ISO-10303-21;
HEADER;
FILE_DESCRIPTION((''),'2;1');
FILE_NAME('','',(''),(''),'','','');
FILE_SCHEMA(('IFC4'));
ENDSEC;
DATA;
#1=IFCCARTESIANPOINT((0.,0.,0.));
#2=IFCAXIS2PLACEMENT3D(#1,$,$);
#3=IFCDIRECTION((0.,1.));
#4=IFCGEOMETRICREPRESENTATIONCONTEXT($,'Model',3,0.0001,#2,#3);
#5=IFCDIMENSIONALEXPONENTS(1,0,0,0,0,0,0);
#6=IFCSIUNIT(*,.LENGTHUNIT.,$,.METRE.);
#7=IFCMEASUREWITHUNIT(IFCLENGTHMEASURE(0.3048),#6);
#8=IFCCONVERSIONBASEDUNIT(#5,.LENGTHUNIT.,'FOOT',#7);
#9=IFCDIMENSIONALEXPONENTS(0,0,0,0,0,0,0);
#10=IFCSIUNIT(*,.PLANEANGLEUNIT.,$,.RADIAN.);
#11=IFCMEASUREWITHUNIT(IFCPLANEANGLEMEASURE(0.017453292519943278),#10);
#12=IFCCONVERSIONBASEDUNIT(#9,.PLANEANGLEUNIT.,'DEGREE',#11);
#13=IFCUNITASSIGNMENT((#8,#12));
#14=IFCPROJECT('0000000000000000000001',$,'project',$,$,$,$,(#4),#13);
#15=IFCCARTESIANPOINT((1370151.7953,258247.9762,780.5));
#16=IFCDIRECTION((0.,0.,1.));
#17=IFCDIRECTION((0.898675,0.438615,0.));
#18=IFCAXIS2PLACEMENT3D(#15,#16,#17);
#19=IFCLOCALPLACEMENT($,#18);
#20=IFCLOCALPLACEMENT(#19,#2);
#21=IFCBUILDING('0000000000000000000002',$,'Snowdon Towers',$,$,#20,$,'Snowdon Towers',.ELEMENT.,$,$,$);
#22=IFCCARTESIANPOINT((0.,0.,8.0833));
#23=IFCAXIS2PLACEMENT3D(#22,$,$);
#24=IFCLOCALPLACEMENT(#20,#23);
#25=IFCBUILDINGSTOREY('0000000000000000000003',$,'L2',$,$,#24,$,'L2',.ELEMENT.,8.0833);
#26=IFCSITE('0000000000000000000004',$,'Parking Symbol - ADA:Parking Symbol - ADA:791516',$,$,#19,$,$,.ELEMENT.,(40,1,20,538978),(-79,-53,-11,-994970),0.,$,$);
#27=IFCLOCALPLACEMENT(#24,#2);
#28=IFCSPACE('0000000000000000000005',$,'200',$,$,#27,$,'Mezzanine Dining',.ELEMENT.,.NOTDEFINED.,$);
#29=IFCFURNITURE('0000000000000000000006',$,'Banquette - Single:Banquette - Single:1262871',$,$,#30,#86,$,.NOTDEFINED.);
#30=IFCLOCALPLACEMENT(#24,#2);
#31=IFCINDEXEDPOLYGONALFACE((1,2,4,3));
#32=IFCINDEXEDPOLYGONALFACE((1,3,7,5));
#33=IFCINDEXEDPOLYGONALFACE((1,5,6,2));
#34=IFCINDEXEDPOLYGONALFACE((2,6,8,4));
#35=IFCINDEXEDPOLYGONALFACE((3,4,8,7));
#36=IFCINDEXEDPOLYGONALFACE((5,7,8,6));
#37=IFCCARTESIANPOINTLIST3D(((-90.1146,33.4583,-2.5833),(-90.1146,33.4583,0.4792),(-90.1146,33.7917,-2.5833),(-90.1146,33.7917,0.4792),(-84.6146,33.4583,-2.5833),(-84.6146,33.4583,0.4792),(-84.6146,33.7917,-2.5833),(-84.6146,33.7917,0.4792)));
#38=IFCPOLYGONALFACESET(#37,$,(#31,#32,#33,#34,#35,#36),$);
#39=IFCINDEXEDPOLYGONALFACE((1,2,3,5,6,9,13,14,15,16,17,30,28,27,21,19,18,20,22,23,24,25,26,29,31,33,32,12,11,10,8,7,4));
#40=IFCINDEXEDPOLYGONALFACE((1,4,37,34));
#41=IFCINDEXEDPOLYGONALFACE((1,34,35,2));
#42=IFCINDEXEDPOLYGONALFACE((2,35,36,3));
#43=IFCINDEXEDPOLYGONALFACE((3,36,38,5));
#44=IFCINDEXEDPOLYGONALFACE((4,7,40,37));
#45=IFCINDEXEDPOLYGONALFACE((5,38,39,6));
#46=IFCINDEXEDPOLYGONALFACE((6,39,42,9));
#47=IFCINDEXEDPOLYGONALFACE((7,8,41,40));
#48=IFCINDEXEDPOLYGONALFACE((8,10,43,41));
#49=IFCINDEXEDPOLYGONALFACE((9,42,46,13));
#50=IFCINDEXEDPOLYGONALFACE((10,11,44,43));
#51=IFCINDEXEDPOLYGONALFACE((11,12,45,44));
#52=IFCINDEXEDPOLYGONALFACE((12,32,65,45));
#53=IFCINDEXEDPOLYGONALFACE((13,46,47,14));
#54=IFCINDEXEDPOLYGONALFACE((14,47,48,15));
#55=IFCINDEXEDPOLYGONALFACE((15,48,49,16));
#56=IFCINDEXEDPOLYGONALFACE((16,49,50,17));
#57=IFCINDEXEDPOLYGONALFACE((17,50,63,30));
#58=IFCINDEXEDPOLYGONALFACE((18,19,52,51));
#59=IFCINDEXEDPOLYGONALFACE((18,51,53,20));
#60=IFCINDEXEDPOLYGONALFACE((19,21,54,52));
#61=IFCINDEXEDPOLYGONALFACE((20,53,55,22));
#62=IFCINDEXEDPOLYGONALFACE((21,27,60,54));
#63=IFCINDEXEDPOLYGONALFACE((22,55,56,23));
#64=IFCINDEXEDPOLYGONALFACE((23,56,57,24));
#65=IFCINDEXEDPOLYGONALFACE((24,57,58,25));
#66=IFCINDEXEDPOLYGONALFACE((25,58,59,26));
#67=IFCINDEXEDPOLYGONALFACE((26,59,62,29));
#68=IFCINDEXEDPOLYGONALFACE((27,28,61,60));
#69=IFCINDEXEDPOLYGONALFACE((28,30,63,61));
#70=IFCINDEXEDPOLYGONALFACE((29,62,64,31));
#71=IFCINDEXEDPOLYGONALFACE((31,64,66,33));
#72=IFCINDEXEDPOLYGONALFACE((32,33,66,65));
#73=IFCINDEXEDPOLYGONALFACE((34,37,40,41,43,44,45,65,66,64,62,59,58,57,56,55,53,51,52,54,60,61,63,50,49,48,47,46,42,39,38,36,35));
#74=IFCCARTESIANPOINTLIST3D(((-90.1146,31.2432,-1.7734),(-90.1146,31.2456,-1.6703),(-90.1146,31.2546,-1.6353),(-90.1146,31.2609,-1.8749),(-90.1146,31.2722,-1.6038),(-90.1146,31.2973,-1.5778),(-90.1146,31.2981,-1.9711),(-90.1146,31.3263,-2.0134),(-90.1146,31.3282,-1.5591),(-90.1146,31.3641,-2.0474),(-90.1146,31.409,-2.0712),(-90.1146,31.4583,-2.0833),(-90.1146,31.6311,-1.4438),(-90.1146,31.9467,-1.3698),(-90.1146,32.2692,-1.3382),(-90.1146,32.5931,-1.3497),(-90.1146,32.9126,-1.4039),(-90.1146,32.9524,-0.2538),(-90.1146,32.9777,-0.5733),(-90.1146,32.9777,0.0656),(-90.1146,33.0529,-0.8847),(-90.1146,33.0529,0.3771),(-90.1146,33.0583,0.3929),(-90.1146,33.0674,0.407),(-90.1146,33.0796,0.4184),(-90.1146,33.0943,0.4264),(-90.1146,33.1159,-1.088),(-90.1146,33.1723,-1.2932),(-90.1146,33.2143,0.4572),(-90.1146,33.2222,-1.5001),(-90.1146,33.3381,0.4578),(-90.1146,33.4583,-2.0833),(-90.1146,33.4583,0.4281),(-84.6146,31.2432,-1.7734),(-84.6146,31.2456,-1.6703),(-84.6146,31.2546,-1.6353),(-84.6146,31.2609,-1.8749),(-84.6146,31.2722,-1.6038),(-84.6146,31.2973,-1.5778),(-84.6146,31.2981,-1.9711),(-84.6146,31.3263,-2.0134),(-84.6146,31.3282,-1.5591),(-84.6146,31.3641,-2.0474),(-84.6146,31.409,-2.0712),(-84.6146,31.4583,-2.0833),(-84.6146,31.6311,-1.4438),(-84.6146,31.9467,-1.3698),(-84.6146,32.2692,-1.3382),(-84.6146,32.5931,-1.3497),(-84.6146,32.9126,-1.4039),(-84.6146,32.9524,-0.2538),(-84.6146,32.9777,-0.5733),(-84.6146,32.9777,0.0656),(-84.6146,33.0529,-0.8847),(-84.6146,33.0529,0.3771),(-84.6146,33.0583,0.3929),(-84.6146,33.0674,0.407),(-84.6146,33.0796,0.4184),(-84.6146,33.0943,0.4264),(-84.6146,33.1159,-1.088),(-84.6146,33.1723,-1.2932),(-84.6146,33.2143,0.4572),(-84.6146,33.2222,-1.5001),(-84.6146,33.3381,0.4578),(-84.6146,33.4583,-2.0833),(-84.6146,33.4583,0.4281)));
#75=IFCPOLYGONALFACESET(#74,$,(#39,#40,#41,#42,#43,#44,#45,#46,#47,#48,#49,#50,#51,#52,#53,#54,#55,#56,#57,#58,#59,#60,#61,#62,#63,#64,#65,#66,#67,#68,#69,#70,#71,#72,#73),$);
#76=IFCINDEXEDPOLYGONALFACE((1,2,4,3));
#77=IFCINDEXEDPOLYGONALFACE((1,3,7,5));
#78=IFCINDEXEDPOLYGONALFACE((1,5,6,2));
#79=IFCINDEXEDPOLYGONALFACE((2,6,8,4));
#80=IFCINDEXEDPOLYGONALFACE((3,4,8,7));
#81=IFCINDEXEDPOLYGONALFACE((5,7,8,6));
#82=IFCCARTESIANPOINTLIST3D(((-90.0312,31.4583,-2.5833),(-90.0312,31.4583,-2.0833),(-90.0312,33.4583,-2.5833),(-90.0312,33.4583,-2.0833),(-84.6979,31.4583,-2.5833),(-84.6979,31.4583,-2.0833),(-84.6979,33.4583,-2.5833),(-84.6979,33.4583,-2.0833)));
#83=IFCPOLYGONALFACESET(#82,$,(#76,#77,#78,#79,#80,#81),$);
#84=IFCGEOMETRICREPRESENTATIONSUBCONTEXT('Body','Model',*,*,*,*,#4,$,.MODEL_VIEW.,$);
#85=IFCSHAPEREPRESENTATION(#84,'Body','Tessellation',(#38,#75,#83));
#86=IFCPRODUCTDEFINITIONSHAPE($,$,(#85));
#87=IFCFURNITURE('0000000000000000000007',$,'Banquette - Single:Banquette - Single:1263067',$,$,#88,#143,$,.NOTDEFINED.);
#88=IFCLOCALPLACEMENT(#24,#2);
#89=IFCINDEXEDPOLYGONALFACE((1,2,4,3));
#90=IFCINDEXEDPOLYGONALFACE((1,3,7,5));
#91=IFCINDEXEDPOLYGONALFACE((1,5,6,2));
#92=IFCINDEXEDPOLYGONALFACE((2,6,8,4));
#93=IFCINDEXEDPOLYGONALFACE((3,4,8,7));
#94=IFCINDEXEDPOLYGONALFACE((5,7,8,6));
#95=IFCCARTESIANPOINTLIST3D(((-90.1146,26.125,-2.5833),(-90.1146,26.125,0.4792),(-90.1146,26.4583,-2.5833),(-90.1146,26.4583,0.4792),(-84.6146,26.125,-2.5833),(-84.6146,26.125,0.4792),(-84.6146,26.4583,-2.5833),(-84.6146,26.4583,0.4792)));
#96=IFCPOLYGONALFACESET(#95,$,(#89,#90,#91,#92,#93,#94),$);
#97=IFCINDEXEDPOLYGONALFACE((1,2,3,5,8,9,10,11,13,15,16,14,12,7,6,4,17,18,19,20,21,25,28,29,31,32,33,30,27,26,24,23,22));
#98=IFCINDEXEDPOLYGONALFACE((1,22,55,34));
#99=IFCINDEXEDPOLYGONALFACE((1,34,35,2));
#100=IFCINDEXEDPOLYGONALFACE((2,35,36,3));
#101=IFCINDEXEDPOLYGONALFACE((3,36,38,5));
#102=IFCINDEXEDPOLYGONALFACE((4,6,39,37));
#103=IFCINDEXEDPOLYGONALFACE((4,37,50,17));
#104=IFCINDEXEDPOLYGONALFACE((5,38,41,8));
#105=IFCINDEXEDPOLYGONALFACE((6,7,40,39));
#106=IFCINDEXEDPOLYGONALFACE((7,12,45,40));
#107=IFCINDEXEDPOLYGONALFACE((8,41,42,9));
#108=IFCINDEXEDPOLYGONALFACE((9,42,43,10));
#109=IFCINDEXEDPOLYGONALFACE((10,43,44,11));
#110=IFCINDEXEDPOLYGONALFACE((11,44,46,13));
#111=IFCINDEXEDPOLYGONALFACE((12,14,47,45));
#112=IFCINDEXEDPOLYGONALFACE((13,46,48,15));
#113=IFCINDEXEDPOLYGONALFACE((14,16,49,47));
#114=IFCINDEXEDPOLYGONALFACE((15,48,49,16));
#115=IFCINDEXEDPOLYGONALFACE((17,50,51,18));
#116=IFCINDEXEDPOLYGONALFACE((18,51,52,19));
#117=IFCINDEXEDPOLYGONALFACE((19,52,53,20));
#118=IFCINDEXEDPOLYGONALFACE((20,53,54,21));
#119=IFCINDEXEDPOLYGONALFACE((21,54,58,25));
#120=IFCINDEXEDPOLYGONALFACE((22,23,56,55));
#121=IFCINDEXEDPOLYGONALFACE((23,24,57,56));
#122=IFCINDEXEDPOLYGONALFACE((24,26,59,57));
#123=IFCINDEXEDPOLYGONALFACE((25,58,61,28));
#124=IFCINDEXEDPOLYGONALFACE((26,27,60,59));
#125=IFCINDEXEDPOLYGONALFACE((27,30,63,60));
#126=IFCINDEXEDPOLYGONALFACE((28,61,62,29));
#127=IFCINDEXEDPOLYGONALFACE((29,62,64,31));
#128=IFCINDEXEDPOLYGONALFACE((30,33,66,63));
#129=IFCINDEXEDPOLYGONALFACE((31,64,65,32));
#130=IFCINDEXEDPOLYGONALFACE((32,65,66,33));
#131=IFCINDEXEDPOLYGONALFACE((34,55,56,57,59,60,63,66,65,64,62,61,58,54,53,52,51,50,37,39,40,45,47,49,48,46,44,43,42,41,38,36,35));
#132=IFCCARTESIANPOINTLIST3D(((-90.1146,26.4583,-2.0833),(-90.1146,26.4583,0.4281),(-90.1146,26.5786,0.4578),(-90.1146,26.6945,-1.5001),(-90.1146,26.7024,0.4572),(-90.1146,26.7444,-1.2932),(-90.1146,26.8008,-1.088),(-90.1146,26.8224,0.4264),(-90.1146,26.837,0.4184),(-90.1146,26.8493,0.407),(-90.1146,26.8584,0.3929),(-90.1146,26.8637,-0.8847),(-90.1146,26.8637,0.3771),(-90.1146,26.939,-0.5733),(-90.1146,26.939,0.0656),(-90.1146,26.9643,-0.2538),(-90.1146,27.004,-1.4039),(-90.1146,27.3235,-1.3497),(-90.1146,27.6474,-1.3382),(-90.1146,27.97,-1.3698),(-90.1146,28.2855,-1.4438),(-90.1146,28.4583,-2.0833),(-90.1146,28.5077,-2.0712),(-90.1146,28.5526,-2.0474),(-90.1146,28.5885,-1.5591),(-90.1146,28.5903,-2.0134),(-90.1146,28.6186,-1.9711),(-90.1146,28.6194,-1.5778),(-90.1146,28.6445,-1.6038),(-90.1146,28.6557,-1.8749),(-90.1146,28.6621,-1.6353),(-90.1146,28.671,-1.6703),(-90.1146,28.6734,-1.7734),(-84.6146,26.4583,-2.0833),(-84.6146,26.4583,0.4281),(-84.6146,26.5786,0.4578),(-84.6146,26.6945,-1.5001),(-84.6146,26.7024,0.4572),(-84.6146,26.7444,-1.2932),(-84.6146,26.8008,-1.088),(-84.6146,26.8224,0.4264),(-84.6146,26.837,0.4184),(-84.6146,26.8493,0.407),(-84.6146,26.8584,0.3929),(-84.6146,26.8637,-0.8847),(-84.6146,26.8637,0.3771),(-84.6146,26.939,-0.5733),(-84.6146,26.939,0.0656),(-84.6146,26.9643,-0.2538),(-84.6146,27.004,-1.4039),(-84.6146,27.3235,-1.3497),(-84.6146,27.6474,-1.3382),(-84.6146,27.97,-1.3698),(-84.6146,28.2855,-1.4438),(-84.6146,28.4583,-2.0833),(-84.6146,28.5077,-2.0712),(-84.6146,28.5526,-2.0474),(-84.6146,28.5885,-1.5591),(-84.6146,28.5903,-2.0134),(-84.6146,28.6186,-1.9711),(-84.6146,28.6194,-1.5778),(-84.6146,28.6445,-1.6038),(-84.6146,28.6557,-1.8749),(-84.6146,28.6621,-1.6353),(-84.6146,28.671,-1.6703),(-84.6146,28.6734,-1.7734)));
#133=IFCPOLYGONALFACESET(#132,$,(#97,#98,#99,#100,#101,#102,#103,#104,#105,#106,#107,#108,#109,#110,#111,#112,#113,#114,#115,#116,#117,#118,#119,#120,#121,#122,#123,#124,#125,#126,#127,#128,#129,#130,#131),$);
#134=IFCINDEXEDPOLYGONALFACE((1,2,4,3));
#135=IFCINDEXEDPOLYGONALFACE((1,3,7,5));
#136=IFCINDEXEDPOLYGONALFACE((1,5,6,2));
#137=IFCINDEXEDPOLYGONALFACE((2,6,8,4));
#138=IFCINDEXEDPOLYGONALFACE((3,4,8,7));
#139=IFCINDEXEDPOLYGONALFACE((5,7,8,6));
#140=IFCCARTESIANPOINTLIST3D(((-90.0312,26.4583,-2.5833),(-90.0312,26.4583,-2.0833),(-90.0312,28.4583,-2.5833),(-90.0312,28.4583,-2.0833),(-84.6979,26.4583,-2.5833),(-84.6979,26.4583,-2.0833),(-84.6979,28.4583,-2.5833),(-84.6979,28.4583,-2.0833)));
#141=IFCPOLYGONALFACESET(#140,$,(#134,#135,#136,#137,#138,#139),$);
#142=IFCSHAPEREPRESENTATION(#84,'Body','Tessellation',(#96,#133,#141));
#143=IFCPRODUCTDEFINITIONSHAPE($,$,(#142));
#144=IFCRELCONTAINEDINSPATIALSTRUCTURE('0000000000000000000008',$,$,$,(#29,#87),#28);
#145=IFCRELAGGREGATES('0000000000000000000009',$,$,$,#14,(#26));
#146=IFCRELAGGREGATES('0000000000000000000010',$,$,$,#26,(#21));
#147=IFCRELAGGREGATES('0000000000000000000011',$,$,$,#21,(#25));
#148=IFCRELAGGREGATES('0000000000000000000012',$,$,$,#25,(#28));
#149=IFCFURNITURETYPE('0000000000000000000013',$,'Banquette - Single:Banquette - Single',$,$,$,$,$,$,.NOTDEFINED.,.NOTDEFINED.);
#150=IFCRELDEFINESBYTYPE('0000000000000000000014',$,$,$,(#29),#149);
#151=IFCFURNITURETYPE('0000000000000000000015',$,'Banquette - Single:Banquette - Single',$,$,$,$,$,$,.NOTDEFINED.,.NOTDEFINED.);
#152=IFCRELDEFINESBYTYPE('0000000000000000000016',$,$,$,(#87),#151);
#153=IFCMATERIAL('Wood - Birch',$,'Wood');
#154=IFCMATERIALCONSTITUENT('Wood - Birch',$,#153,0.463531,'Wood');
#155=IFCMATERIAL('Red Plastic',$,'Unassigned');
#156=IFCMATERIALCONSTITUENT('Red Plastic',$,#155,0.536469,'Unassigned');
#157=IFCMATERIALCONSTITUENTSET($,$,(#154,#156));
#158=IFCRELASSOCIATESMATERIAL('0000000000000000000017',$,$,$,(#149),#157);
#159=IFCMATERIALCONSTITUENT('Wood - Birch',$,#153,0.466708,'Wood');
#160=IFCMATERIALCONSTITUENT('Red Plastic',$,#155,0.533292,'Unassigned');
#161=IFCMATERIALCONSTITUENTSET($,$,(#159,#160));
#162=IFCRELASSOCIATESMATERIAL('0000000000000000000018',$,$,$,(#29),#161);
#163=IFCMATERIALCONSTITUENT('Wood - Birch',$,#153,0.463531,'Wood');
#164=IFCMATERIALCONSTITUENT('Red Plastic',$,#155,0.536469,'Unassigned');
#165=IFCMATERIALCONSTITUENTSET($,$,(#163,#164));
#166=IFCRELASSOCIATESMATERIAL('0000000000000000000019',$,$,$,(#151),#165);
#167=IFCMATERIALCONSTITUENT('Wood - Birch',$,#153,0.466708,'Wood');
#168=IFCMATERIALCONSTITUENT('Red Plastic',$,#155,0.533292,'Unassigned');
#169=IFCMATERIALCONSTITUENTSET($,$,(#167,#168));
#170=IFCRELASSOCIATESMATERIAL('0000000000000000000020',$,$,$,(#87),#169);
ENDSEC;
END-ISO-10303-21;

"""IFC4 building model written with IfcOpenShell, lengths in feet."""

from ifc_helpers import new_model, entity, si_unit, converted_unit, direction, frame, origin, place, context, subcontext, project, spatial, line, arc, indexed_curve, outline, extrude, source, transform, mapped, material, constituent, constituent_set, type_object, type_shapes, element, save


model = new_model("IFC4")

# Units and contexts
model_context = context("Model", 3, precision=0.0001, world=origin(), true_north=direction((0.0, 1.0)))
body_context = subcontext(model_context, "Body", "Model", "MODEL_VIEW")
ifc_project = project(units=[converted_unit("LENGTHUNIT", "FOOT", entity("IfcLengthMeasure", 0.3048), si_unit("LENGTHUNIT", "METRE"), dimensions=[1, 0, 0, 0, 0, 0, 0]), converted_unit("PLANEANGLEUNIT", "DEGREE", entity("IfcPlaneAngleMeasure", 0.017453292519943278), si_unit("PLANEANGLEUNIT", "RADIAN"), dimensions=[0, 0, 0, 0, 0, 0, 0])], contexts=[model_context])

# Site, building, storey
site_placement = place(None, frame((1370151.7953, 258247.9762, 780.5), z_axis=(0.0, 0.0, 1.0), x_axis=(0.898675, 0.438615, 0.0)))
site = spatial("IfcSite", under=ifc_project, at=site_placement, Name="Parking Symbol - ADA:Parking Symbol - ADA:791516", CompositionType="ELEMENT", RefLatitude=(40, 1, 20, 538978), RefLongitude=(-79, -53, -11, -994970), RefElevation=0.0)
building_placement = place(site_placement, origin())
building = spatial("IfcBuilding", under=site, at=building_placement, Name="Snowdon Towers", LongName="Snowdon Towers", CompositionType="ELEMENT")
storey_placement = place(building_placement, frame((0.0, 0.0, 8.0833)))
storey = spatial("IfcBuildingStorey", under=building, at=storey_placement, Name="L2", LongName="L2", CompositionType="ELEMENT", Elevation=8.0833)

# Shared definitions
space_1_placement = place(storey_placement, origin())
space_1 = spatial("IfcSpace", under=storey, at=space_1_placement, Name="200", LongName="Mezzanine Dining", CompositionType="ELEMENT", PredefinedType="NOTDEFINED")

# Furniture
ifc_material_1 = material(Name="Wood - Birch", Category="Wood")
ifc_constituent_1 = constituent(ifc_material_1, Name="Wood - Birch", Category="Wood", fraction=0.466708)
ifc_material_2 = material(Name="Red Plastic", Category="Unassigned")
ifc_constituent_2 = constituent(ifc_material_2, Name="Red Plastic", Category="Unassigned", fraction=0.533292)
ifc_constituent_set_1 = constituent_set(constituents=[ifc_constituent_1, ifc_constituent_2])
ifc_constituent_3 = constituent(ifc_material_1, Name="Wood - Birch", Category="Wood", fraction=0.463531)
ifc_constituent_4 = constituent(ifc_material_2, Name="Red Plastic", Category="Unassigned", fraction=0.536469)
ifc_constituent_set_2 = constituent_set(constituents=[ifc_constituent_3, ifc_constituent_4])
furniture_type_1 = type_object("IfcFurnitureType", Name="Banquette - Single:Banquette - Single", AssemblyPlace="NOTDEFINED", PredefinedType="NOTDEFINED", material=ifc_constituent_set_2)
shared_shape_1 = source(origin(), body_context, "Body", "SweptSolid", [
    extrude(outline(indexed_curve([(-2.75, -0.1667), (2.75, -0.1667), (2.75, 0.1667), (-2.75, 0.1667), (-2.75, -0.1667)], self_intersect=False)), frame((-0.1667, -2.75, 0.0), z_axis=(0.0, 0.0, 1.0), x_axis=(0.0, -1.0, 0.0)), (0.0, 0.0, 1.0), 3.0625),
    extrude(outline(indexed_curve([(1.1689, 0.9191), (1.1029, 0.9954), (1.0086, 1.0313), (-0.9914, 1.0313), (-0.9914, -1.4801), (-0.8092, -1.5134), (-0.6274, -1.4784), (-0.6004, -1.459), (-0.586, -1.4291), (-0.4855, -0.7982), (-0.586, -0.1673), (-0.678, 0.1384), (-0.7552, 0.4481), (0.1977, 0.2862), (1.1387, 0.507), (1.1947, 0.5517), (1.2213, 0.6183), (1.2173, 0.7725)], segments=[arc(1, 2, 3), line(3, 4, 5), arc(5, 6, 7), arc(7, 8, 9), arc(9, 10, 11), arc(11, 12, 13), arc(13, 14, 15), arc(15, 16, 17), arc(17, 18, 1)], self_intersect=False)), frame((0.9914, -5.5, 1.5313), z_axis=(0.0, 1.0, 0.0), x_axis=(1.0, 0.0, 0.0)), (0.0, 0.0, 1.0), 5.5),
    extrude(outline(indexed_curve([(-1.0, -2.6667), (1.0, -2.6667), (1.0, 2.6667), (-1.0, 2.6667), (-1.0, -2.6667)], self_intersect=False)), frame((1.0, -2.75, 0.0), z_axis=(0.0, 0.0, 1.0), x_axis=(-1.0, 0.0, 0.0)), (0.0, 0.0, 1.0), 0.5),
])
type_shapes(furniture_type_1, [shared_shape_1])
furniture_1_placement = place(space_1_placement, frame((-84.6146, 33.4583, -2.5833), z_axis=(0.0, 0.0, 1.0), x_axis=(0.0, -1.0, 0.0)))
element("IfcFurniture", 1, at=furniture_1_placement, inside=space_1, type_object=furniture_type_1, material=ifc_constituent_set_1, Name="Banquette - Single:Banquette - Single:1262871", PredefinedType="NOTDEFINED", context=body_context, shape_type="MappedRepresentation", body=[
    mapped(shared_shape_1, transform((0.0, 0.0, 0.0), scale=1.0)),
])
ifc_constituent_5 = constituent(ifc_material_1, Name="Wood - Birch", Category="Wood", fraction=0.466708)
ifc_constituent_6 = constituent(ifc_material_2, Name="Red Plastic", Category="Unassigned", fraction=0.533292)
ifc_constituent_set_3 = constituent_set(constituents=[ifc_constituent_5, ifc_constituent_6])
ifc_constituent_7 = constituent(ifc_material_1, Name="Wood - Birch", Category="Wood", fraction=0.463531)
ifc_constituent_8 = constituent(ifc_material_2, Name="Red Plastic", Category="Unassigned", fraction=0.536469)
ifc_constituent_set_4 = constituent_set(constituents=[ifc_constituent_7, ifc_constituent_8])
furniture_type_2 = type_object("IfcFurnitureType", Name="Banquette - Single:Banquette - Single", AssemblyPlace="NOTDEFINED", PredefinedType="NOTDEFINED", material=ifc_constituent_set_4)
shared_shape_2 = source(origin(), body_context, "Body", "SweptSolid", [
    extrude(outline(indexed_curve([(-0.1667, -2.75), (0.1667, -2.75), (0.1667, 2.75), (-0.1667, 2.75), (-0.1667, -2.75)], self_intersect=False)), frame((-0.1667, 2.75, 0.0)), (0.0, 0.0, 1.0), 3.0625),
    extrude(outline(indexed_curve([(1.1689, 0.9191), (1.1029, 0.9954), (1.0086, 1.0313), (-0.9914, 1.0313), (-0.9914, -1.4801), (-0.8092, -1.5134), (-0.6274, -1.4784), (-0.6004, -1.459), (-0.586, -1.4291), (-0.4855, -0.7982), (-0.586, -0.1673), (-0.678, 0.1384), (-0.7552, 0.4481), (0.1977, 0.2862), (1.1387, 0.507), (1.1947, 0.5517), (1.2213, 0.6183), (1.2173, 0.7725)], segments=[arc(1, 2, 3), line(3, 4, 5), arc(5, 6, 7), arc(7, 8, 9), arc(9, 10, 11), arc(11, 12, 13), arc(13, 14, 15), arc(15, 16, 17), arc(17, 18, 1)], self_intersect=False)), frame((0.9914, 0.0, 1.5313), z_axis=(0.0, 1.0, 0.0), x_axis=(1.0, 0.0, 0.0)), (0.0, 0.0, 1.0), 5.5),
    extrude(outline(indexed_curve([(-2.6667, -1.0), (2.6667, -1.0), (2.6667, 1.0), (-2.6667, 1.0), (-2.6667, -1.0)], self_intersect=False)), frame((1.0, 2.75, 0.0), z_axis=(0.0, 0.0, 1.0), x_axis=(0.0, 1.0, 0.0)), (0.0, 0.0, 1.0), 0.5),
])
type_shapes(furniture_type_2, [shared_shape_2])
furniture_2_placement = place(space_1_placement, frame((-84.6146, 26.4583, -2.5833), z_axis=(0.0, 0.0, 1.0), x_axis=(0.0, 1.0, 0.0)))
element("IfcFurniture", 2, at=furniture_2_placement, inside=space_1, type_object=furniture_type_2, material=ifc_constituent_set_3, Name="Banquette - Single:Banquette - Single:1263067", PredefinedType="NOTDEFINED", context=body_context, shape_type="MappedRepresentation", body=[
    mapped(shared_shape_2, transform((0.0, 0.0, 0.0), scale=1.0)),
])

save(model, "model.ifc")
